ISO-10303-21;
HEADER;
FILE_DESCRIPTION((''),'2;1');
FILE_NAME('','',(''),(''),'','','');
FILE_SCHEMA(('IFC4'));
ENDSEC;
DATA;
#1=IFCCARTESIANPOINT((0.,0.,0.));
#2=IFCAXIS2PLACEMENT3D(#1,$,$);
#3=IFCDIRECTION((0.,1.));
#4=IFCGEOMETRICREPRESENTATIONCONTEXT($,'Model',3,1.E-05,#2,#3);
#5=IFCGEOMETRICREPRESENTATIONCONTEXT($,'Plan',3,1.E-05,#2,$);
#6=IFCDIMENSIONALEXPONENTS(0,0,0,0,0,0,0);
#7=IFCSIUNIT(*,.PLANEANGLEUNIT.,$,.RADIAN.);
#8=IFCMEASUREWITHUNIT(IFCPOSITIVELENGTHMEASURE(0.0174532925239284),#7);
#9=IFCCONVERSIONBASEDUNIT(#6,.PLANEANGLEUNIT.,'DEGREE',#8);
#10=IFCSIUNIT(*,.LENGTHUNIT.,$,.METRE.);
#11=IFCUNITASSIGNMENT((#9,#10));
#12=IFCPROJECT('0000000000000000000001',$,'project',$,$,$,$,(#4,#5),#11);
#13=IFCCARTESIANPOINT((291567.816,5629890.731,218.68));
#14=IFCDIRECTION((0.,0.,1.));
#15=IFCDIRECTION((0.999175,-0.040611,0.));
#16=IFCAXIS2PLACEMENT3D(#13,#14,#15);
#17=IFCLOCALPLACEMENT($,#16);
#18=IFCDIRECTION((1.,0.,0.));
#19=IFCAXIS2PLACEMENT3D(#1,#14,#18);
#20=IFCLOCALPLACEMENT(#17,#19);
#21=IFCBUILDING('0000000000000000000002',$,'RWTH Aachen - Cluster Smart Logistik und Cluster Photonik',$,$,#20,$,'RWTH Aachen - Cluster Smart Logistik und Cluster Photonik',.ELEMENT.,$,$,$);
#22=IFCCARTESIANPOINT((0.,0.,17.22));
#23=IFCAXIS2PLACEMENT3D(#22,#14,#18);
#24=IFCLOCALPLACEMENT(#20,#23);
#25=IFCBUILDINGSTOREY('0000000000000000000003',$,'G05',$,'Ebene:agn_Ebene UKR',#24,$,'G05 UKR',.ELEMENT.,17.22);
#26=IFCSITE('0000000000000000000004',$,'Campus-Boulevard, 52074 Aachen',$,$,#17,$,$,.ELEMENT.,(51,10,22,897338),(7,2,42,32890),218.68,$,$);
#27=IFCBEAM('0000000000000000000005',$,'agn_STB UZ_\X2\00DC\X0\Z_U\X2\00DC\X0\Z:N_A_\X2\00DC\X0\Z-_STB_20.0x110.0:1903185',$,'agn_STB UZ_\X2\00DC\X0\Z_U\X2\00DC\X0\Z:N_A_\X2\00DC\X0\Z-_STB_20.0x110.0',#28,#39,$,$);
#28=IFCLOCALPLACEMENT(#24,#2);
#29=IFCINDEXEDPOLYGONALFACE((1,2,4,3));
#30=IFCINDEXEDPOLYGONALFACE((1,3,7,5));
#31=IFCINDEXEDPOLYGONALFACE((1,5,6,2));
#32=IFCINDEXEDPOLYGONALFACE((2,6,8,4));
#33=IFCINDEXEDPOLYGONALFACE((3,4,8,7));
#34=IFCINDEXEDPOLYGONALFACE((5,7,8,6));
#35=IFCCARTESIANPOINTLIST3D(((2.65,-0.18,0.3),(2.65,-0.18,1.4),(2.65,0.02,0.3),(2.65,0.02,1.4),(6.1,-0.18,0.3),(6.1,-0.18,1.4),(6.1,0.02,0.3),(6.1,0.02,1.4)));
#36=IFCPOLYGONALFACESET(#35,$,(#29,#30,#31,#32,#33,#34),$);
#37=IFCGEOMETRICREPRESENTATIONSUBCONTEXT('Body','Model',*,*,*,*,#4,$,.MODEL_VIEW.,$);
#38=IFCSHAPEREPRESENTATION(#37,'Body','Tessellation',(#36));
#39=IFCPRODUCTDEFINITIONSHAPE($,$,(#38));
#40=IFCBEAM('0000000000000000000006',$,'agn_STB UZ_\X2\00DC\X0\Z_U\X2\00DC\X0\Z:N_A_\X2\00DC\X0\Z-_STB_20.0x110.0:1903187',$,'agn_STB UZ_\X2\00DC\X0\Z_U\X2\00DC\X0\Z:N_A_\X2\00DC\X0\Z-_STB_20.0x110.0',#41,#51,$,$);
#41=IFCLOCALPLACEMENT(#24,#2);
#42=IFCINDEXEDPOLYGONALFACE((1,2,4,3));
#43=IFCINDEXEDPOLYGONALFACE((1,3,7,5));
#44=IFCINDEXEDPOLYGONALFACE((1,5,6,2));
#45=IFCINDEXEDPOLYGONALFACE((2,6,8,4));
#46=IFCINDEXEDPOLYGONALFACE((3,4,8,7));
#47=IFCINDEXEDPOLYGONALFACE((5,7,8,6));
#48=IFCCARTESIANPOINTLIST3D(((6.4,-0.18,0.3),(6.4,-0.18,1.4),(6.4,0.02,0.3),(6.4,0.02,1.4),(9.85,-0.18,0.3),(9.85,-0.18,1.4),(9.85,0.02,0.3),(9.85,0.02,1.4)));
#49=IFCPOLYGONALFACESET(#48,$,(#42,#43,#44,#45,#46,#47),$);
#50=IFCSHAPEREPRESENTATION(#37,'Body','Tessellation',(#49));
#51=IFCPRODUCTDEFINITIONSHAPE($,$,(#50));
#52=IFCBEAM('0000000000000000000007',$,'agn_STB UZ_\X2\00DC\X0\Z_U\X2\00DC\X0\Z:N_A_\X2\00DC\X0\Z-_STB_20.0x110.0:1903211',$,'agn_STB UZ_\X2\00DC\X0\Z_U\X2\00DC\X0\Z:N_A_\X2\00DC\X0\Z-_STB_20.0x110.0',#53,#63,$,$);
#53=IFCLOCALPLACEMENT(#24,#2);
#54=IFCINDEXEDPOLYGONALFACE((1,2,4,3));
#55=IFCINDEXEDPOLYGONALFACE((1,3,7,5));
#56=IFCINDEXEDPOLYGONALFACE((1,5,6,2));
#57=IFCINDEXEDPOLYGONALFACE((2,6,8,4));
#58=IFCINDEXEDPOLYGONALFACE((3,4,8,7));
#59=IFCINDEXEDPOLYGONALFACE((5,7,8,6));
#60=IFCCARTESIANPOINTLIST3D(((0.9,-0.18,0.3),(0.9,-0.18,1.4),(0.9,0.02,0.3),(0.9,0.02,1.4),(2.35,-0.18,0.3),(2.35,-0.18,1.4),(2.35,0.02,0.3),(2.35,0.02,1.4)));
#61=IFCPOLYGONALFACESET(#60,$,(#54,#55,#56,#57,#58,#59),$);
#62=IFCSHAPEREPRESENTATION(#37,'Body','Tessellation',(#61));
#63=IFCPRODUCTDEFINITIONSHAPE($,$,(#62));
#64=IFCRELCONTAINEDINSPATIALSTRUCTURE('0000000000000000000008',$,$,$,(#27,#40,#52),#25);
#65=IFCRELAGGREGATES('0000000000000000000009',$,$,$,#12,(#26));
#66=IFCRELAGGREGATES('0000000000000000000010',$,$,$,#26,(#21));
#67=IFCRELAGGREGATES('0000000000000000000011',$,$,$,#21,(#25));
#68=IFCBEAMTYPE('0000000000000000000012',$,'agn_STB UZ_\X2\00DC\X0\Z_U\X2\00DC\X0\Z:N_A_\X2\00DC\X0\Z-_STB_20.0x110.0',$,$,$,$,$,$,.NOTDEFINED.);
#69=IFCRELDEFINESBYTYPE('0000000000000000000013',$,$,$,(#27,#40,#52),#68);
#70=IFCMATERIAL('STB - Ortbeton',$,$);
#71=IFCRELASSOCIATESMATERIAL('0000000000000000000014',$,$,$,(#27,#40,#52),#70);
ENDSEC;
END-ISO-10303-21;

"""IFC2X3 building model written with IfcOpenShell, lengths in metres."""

from ifc_helpers import new_model, entity, si_unit, converted_unit, direction, frame, frame_2d, origin, origin_with_axes, place, context, subcontext, project, spatial, rectangle, extrude, material, type_object, element, save


model = new_model("IFC2X3")

# Units and contexts
model_context = context("Model", 3, precision=1e-05, world=origin(), true_north=direction((0.0, 1.0)))
plan_context = context("Plan", 3, precision=1e-05, world=origin())
body_context = subcontext(model_context, "Body", "Model", "MODEL_VIEW")
ifc_project = project(units=[converted_unit("PLANEANGLEUNIT", "DEGREE", entity("IfcPositiveLengthMeasure", 0.0174532925239284), si_unit("PLANEANGLEUNIT", "RADIAN"), dimensions=[0, 0, 0, 0, 0, 0, 0]), si_unit("LENGTHUNIT", "METRE")], contexts=[model_context, plan_context])

# Site, building, storey
site_placement = place(None, frame((291567.816, 5629890.731, 218.68), z_axis=(0.0, 0.0, 1.0), x_axis=(0.999175, -0.040611, 0.0)))
site = spatial("IfcSite", under=ifc_project, at=site_placement, Name="Campus-Boulevard, 52074 Aachen", CompositionType="ELEMENT", RefLatitude=(51, 10, 22, 897338), RefLongitude=(7, 2, 42, 32890), RefElevation=218.68)
building_placement = place(site_placement, origin_with_axes())
building = spatial("IfcBuilding", under=site, at=building_placement, Name="RWTH Aachen - Cluster Smart Logistik und Cluster Photonik", LongName="RWTH Aachen - Cluster Smart Logistik und Cluster Photonik", CompositionType="ELEMENT")
storey_placement = place(building_placement, frame((0.0, 0.0, 17.22), z_axis=(0.0, 0.0, 1.0), x_axis=(1.0, 0.0, 0.0)))
storey = spatial("IfcBuildingStorey", under=building, at=storey_placement, Name="G05", ObjectType="Ebene:agn_Ebene UKR", LongName="G05 UKR", CompositionType="ELEMENT", Elevation=17.22)

# Shared definitions
ifc_material_1 = material(Name="STB - Ortbeton")

# Beams
beam_type_1 = type_object("IfcBeamType", Name="agn_STB UZ_ÜZ_UÜZ:N_A_ÜZ-_STB_20.0x110.0", PredefinedType="NOTDEFINED")
for number, where, z_axis, x_axis, name in (
    (1, (2.65, -0.08, 0.3), (0.0, 0.0, 1.0), (1.0, 0.0, 0.0), "agn_STB UZ_ÜZ_UÜZ:N_A_ÜZ-_STB_20.0x110.0:1903185"),
    (2, (6.4, -0.08, 0.3), (0.0, 0.0, 1.0), (1.0, 0.0, 0.0), "agn_STB UZ_ÜZ_UÜZ:N_A_ÜZ-_STB_20.0x110.0:1903187"),
):
    element("IfcBeam", number, at=place(storey_placement, frame(where, z_axis=z_axis, x_axis=x_axis)), inside=storey, type_object=beam_type_1, material=ifc_material_1, Name=name, ObjectType="agn_STB UZ_ÜZ_UÜZ:N_A_ÜZ-_STB_20.0x110.0", context=body_context, shape_type="SweptSolid", body=[
        extrude(rectangle(XDim=1.1, YDim=0.2, at=frame_2d((0.0, 0.0), x_axis=(1.0, 0.0))), frame((0.0, 0.0, 0.55), z_axis=(1.0, 0.0, 0.0), x_axis=(0.0, 0.0, -1.0)), (0.0, 0.0, 1.0), 3.45),
    ])
beam_1_placement = place(storey_placement, frame((0.9, -0.08, 0.3), z_axis=(0.0, 0.0, 1.0), x_axis=(1.0, 0.0, 0.0)))
element("IfcBeam", 3, at=beam_1_placement, inside=storey, type_object=beam_type_1, material=ifc_material_1, Name="agn_STB UZ_ÜZ_UÜZ:N_A_ÜZ-_STB_20.0x110.0:1903211", ObjectType="agn_STB UZ_ÜZ_UÜZ:N_A_ÜZ-_STB_20.0x110.0", context=body_context, shape_type="SweptSolid", body=[
    extrude(rectangle(XDim=1.1, YDim=0.2, at=frame_2d((0.0, 0.0), x_axis=(1.0, 0.0))), frame((0.0, 0.0, 0.55), z_axis=(1.0, 0.0, 0.0), x_axis=(0.0, 0.0, -1.0)), (0.0, 0.0, 1.0), 1.45),
])

save(model, "model.ifc")
